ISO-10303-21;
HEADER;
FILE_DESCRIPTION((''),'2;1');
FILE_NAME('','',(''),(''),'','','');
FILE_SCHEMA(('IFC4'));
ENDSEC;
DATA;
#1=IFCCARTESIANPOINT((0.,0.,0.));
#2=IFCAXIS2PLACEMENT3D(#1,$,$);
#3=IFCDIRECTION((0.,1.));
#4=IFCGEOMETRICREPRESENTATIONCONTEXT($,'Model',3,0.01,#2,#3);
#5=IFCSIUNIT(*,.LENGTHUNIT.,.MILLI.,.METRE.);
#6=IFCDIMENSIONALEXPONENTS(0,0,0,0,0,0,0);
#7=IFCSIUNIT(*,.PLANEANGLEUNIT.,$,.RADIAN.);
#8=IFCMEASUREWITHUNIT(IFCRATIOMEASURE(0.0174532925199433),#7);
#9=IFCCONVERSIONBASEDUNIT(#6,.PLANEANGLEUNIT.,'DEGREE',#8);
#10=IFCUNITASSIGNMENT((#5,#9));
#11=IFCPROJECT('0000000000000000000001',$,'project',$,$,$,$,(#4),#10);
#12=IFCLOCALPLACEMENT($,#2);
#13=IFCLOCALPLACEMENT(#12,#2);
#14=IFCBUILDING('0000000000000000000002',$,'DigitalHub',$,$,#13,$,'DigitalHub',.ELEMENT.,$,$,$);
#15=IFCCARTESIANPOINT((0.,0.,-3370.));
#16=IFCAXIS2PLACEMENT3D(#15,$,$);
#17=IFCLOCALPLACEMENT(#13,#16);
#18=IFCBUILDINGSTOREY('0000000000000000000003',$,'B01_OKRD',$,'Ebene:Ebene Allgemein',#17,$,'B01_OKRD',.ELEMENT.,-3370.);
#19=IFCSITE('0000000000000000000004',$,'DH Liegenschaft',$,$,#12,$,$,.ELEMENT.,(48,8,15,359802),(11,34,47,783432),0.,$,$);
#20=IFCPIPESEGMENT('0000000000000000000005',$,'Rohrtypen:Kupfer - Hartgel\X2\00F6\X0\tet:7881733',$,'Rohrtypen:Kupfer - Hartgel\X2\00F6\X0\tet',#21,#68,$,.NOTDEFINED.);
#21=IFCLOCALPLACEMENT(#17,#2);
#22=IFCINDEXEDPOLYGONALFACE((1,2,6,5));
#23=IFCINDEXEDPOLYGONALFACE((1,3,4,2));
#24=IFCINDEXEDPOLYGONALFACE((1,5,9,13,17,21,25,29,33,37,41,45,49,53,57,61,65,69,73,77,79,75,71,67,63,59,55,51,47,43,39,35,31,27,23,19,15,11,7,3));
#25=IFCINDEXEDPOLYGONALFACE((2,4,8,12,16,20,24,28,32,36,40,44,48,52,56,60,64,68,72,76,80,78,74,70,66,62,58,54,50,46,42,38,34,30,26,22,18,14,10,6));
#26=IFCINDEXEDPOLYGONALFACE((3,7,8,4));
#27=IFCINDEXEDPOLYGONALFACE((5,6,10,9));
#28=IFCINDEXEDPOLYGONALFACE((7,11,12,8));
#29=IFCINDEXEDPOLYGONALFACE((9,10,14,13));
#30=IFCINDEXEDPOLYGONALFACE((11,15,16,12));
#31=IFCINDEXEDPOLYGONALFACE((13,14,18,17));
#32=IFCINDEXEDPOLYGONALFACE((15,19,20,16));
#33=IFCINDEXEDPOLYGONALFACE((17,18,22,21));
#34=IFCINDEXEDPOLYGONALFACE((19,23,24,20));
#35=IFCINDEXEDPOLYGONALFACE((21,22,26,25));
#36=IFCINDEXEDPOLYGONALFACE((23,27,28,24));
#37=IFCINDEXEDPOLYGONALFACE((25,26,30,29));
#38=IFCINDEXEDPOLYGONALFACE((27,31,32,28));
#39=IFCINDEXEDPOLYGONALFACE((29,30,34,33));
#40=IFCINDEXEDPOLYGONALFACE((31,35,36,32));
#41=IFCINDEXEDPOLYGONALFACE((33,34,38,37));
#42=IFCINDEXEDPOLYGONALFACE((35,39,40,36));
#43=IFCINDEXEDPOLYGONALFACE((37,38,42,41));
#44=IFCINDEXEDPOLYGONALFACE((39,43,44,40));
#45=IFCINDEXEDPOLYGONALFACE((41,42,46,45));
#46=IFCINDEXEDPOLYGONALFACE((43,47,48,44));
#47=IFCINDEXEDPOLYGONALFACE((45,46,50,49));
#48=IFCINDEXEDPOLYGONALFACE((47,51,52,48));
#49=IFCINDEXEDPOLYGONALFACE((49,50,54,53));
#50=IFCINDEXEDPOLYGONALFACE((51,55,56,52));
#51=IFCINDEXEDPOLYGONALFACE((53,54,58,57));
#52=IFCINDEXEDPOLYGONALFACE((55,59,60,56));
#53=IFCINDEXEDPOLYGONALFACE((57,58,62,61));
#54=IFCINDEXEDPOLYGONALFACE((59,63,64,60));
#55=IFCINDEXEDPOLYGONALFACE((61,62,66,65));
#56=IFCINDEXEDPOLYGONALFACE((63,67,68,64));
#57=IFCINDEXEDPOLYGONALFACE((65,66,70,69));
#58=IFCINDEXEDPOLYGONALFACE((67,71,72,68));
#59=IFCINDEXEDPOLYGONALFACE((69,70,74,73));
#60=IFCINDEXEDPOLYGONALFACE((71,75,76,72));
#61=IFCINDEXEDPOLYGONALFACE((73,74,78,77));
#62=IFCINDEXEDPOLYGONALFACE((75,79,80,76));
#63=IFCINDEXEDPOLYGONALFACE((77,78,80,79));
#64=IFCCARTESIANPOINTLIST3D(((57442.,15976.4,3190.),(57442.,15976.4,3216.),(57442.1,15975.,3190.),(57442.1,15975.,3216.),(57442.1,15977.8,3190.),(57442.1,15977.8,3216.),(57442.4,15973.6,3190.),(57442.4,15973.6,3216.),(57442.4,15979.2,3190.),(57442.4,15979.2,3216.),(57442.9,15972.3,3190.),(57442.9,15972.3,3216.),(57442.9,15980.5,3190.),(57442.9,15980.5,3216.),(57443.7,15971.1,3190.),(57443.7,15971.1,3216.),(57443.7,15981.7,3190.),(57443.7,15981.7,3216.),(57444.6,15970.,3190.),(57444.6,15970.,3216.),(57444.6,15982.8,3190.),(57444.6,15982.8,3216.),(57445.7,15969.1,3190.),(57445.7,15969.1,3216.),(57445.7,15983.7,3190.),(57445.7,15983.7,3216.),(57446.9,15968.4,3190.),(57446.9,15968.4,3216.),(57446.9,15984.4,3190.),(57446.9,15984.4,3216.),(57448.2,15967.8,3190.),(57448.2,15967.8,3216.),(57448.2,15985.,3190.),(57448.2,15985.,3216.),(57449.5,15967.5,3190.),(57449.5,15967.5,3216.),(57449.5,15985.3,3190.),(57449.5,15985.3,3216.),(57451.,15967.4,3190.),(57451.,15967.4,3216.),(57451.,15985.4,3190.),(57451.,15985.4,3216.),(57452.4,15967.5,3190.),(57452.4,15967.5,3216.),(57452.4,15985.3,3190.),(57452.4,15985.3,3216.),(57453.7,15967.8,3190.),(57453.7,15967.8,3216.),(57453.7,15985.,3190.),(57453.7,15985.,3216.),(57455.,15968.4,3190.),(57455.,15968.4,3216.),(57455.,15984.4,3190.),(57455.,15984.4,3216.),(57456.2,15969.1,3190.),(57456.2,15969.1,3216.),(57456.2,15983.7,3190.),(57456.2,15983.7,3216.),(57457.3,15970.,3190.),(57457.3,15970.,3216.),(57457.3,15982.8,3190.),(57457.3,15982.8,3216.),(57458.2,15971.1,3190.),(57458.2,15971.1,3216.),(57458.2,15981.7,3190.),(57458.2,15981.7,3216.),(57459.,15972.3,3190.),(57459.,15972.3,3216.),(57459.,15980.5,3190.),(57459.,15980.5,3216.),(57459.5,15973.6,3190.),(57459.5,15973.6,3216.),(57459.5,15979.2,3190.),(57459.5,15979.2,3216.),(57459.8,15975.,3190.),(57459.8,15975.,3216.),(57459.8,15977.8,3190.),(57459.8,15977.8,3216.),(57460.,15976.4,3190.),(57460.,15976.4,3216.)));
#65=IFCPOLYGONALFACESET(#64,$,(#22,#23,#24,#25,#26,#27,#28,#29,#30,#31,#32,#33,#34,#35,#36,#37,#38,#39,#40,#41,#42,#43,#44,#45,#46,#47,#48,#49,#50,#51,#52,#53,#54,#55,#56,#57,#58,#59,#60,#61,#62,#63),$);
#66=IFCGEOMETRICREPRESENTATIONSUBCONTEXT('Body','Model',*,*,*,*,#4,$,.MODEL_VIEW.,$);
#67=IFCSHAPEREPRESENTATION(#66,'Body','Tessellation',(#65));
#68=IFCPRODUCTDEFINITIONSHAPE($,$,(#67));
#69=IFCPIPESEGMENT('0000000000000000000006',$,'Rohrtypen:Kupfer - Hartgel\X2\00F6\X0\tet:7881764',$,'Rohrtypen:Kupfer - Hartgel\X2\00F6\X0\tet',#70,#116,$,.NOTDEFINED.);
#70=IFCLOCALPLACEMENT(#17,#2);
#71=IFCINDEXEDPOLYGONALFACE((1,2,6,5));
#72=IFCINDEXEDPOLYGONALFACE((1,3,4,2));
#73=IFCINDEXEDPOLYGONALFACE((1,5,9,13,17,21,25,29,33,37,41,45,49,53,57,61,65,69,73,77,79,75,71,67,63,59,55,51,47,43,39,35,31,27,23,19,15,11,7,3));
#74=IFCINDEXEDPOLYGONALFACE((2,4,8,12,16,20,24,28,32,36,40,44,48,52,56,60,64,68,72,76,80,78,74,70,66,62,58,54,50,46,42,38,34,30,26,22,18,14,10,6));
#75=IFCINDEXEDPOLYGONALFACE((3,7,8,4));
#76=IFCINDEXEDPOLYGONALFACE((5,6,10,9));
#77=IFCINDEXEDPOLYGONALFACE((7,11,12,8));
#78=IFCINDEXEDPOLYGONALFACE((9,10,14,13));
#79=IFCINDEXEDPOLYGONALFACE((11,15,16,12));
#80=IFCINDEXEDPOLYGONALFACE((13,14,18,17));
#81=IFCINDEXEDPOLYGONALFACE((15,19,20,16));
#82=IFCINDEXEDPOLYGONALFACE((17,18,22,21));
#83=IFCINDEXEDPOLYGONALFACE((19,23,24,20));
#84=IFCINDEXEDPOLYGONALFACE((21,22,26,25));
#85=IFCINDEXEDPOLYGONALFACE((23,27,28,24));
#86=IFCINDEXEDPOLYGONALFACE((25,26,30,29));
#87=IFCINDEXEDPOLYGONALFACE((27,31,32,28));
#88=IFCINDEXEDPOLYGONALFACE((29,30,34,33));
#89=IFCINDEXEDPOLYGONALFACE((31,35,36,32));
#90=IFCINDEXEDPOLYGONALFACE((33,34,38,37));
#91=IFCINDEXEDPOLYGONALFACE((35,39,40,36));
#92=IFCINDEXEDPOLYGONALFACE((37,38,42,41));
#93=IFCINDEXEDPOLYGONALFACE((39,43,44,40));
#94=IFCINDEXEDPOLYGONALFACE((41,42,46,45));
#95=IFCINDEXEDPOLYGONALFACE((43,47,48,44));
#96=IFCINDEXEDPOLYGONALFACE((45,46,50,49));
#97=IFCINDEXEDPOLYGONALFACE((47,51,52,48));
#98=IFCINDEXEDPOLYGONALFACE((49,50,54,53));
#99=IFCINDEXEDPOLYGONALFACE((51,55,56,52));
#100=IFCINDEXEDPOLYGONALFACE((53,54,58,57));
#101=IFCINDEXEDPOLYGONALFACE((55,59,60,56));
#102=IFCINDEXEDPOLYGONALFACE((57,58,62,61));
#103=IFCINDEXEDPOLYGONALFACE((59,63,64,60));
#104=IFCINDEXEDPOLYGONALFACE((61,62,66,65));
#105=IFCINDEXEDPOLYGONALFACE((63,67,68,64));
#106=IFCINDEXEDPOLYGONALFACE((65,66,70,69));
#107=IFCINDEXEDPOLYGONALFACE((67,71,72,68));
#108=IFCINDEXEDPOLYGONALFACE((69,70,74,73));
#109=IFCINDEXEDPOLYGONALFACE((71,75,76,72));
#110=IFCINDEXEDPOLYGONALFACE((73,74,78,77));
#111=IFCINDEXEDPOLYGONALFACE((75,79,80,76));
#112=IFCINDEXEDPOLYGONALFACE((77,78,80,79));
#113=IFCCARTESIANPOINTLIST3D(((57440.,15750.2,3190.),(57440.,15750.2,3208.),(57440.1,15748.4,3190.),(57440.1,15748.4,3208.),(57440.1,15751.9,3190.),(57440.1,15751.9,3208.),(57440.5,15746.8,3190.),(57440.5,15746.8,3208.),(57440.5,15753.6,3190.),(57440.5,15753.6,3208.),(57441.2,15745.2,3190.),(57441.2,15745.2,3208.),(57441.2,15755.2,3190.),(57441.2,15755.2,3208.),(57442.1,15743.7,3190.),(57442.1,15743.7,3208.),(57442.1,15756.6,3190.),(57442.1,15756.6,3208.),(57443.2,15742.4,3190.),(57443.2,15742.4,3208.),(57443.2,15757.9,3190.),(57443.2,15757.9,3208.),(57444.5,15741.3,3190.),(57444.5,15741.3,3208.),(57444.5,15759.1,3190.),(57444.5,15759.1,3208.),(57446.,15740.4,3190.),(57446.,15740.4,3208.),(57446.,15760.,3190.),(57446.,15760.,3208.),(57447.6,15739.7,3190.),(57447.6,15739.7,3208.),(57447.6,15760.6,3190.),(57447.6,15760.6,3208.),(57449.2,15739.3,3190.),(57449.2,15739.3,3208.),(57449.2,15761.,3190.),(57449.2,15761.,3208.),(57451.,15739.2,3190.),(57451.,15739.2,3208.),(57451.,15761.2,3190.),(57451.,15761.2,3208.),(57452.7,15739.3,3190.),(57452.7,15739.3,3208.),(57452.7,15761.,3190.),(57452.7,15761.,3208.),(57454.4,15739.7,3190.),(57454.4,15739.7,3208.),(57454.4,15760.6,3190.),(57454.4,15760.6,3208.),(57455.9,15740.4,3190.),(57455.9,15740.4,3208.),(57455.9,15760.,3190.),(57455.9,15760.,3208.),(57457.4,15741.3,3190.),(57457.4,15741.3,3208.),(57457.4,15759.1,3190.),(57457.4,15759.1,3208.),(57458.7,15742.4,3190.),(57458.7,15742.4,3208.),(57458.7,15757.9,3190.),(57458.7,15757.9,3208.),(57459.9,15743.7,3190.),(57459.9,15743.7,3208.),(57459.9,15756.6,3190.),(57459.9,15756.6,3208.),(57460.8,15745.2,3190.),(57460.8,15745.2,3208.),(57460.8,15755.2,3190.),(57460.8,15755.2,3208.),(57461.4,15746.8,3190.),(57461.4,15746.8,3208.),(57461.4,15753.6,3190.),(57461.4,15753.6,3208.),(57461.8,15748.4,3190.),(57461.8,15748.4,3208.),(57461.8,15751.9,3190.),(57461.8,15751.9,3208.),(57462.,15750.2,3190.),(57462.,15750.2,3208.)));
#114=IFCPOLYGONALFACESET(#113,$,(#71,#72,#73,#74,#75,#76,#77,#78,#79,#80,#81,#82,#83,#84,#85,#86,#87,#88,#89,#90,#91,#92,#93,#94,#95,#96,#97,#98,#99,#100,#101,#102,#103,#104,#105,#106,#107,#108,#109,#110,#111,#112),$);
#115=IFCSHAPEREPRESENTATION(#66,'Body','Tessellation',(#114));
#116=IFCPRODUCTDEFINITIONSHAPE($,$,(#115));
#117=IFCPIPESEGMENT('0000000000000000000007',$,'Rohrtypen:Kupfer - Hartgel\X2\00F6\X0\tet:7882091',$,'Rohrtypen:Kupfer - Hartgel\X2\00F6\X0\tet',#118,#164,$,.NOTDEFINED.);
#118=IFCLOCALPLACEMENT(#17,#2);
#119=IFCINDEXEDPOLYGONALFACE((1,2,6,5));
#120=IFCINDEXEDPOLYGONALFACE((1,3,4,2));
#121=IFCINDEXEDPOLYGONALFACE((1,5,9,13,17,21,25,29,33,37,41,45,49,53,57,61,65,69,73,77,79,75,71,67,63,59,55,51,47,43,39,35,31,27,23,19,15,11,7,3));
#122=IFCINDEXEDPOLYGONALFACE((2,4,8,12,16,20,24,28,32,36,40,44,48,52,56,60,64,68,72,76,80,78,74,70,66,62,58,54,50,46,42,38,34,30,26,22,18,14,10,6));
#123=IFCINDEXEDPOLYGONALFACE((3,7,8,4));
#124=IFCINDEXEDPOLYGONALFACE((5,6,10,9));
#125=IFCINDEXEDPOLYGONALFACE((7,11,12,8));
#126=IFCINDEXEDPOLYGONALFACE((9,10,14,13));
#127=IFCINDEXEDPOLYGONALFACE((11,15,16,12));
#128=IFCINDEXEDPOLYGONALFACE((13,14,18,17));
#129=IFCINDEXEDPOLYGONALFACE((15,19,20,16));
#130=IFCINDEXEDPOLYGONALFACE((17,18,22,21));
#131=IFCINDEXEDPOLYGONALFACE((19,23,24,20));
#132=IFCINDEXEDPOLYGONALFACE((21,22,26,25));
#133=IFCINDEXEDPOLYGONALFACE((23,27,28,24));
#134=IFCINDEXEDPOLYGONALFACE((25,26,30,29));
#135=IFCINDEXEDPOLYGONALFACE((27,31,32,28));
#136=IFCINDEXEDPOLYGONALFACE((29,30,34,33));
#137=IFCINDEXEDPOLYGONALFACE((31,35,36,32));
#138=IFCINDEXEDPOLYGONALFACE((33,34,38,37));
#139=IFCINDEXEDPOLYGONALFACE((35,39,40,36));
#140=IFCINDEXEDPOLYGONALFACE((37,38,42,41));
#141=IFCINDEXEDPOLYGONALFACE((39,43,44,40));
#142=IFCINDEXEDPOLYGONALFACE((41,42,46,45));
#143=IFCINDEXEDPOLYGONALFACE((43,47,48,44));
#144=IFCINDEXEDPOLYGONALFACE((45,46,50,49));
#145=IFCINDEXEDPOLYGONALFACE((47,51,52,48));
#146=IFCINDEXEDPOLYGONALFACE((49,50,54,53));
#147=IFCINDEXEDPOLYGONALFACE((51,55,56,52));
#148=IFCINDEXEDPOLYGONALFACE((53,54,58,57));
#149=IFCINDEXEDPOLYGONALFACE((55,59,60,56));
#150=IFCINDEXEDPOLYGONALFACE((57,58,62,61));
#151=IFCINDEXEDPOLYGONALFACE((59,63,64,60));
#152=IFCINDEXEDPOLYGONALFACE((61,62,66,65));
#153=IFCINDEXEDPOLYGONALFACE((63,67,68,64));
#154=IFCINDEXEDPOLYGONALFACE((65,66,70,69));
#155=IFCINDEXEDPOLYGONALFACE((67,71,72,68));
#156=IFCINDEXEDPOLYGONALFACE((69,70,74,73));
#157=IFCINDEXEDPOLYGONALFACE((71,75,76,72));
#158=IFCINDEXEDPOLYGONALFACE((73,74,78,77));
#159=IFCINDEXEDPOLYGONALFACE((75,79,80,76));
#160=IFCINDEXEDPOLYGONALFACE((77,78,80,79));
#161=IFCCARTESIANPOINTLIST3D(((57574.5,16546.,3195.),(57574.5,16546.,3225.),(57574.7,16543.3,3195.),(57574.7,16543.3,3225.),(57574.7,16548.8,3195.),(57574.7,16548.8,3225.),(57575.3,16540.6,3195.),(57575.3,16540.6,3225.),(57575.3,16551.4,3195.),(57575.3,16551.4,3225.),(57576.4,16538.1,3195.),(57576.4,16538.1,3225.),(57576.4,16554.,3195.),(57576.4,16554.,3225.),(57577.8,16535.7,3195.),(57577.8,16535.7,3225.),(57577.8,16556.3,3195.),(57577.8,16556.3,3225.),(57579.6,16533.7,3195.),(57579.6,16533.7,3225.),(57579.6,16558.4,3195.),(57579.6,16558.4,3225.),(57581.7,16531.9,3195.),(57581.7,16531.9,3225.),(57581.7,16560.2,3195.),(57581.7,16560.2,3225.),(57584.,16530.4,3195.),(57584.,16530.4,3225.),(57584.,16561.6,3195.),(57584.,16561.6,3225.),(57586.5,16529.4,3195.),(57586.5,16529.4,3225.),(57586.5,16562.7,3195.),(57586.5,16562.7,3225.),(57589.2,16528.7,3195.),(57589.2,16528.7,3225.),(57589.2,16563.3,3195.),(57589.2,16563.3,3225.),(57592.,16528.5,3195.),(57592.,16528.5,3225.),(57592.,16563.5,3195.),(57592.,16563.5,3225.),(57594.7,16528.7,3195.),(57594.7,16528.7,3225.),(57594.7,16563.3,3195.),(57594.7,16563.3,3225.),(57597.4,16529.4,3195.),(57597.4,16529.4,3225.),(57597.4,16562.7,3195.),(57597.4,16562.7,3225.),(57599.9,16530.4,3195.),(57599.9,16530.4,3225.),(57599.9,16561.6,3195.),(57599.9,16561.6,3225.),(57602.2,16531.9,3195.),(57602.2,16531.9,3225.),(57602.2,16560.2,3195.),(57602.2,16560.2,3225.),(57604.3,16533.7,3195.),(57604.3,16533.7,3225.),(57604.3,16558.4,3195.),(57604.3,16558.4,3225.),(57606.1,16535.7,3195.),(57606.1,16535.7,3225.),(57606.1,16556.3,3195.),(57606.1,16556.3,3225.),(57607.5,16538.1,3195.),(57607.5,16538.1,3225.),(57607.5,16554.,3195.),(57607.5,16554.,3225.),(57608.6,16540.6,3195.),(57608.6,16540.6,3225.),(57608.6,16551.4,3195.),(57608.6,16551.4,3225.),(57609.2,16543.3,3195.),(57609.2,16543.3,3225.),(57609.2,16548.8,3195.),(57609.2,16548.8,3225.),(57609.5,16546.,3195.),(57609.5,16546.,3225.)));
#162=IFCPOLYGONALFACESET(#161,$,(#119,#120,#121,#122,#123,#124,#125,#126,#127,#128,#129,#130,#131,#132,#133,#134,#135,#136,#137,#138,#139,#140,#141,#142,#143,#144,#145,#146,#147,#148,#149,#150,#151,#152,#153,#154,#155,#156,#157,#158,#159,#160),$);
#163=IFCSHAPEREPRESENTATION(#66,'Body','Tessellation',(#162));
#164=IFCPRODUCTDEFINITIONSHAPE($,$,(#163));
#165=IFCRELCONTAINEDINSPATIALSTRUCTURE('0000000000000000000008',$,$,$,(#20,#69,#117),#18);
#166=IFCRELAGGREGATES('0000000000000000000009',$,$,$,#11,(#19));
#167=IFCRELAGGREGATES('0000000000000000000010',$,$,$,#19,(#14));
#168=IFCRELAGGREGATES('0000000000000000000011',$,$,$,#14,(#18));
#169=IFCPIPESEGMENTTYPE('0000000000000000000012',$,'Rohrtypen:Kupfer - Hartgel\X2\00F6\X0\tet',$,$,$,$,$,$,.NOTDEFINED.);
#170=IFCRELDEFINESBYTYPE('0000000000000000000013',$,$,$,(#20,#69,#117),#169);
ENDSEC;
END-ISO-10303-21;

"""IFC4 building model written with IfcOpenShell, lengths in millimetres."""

from ifc_helpers import new_model, entity, si_unit, converted_unit, direction, frame, origin, place, context, subcontext, project, spatial, indexed_curve, outline, extrude, type_object, element, save


model = new_model("IFC4")

# Units and contexts
model_context = context("Model", 3, precision=0.01, world=origin(), true_north=direction((0.0, 1.0)))
body_context = subcontext(model_context, "Body", "Model", "MODEL_VIEW")
ifc_project = project(units=[si_unit("LENGTHUNIT", "METRE", prefix="MILLI"), converted_unit("PLANEANGLEUNIT", "DEGREE", entity("IfcRatioMeasure", 0.0174532925199433), si_unit("PLANEANGLEUNIT", "RADIAN"), dimensions=[0, 0, 0, 0, 0, 0, 0])], contexts=[model_context])

# Site, building, storey
site_placement = place(None, origin())
site = spatial("IfcSite", under=ifc_project, at=site_placement, Name="DH Liegenschaft", CompositionType="ELEMENT", RefLatitude=(48, 8, 15, 359802), RefLongitude=(11, 34, 47, 783432), RefElevation=0.0)
building_placement = place(site_placement, origin())
building = spatial("IfcBuilding", under=site, at=building_placement, Name="DigitalHub", LongName="DigitalHub", CompositionType="ELEMENT")
storey_placement = place(building_placement, frame((0.0, 0.0, -3370.0)))
storey = spatial("IfcBuildingStorey", under=building, at=storey_placement, Name="B01_OKRD", ObjectType="Ebene:Ebene Allgemein", LongName="B01_OKRD", CompositionType="ELEMENT", Elevation=-3370.0)

# Pipe segments
pipe_segment_type = type_object("IfcPipeSegmentType", Name="Rohrtypen:Kupfer - Hartgelötet", PredefinedType="NOTDEFINED")
pipe_segment_1_placement = place(storey_placement, frame((57440.4, 15965.8, 3190.0)))
element("IfcPipeSegment", 1, at=pipe_segment_1_placement, inside=storey, type_object=pipe_segment_type, Name="Rohrtypen:Kupfer - Hartgelötet:7881733", ObjectType="Rohrtypen:Kupfer - Hartgelötet", PredefinedType="NOTDEFINED", context=body_context, shape_type="SweptSolid", body=[
    extrude(outline(indexed_curve([(9.0, 0.0), (8.9, 1.4), (8.6, 2.8), (8.0, 4.1), (7.3, 5.3), (6.4, 6.4), (5.3, 7.3), (4.1, 8.0), (2.8, 8.6), (1.4, 8.9), (0.0, 9.0), (-1.4, 8.9), (-2.8, 8.6), (-4.1, 8.0), (-5.3, 7.3), (-6.4, 6.4), (-7.3, 5.3), (-8.0, 4.1), (-8.6, 2.8), (-8.9, 1.4), (-9.0, 0.0), (-8.9, -1.4), (-8.6, -2.8), (-8.0, -4.1), (-7.3, -5.3), (-6.4, -6.4), (-5.3, -7.3), (-4.1, -8.0), (-2.8, -8.6), (-1.4, -8.9), (0.0, -9.0), (1.4, -8.9), (2.8, -8.6), (4.1, -8.0), (5.3, -7.3), (6.4, -6.4), (7.3, -5.3), (8.0, -4.1), (8.6, -2.8), (8.9, -1.4), (9.0, 0.0)], self_intersect=False)), frame((10.6, 10.6, 0.0)), (0.0, 0.0, 1.0), 26.0),
])
pipe_segment_2_placement = place(storey_placement, frame((57438.4, 15737.6, 3190.0)))
element("IfcPipeSegment", 2, at=pipe_segment_2_placement, inside=storey, type_object=pipe_segment_type, Name="Rohrtypen:Kupfer - Hartgelötet:7881764", ObjectType="Rohrtypen:Kupfer - Hartgelötet", PredefinedType="NOTDEFINED", context=body_context, shape_type="SweptSolid", body=[
    extrude(outline(indexed_curve([(11.0, 0.0), (10.9, 1.7), (10.5, 3.4), (9.8, 5.0), (8.9, 6.5), (7.8, 7.8), (6.5, 8.9), (5.0, 9.8), (3.4, 10.5), (1.7, 10.9), (0.0, 11.0), (-1.7, 10.9), (-3.4, 10.5), (-5.0, 9.8), (-6.5, 8.9), (-7.8, 7.8), (-8.9, 6.5), (-9.8, 5.0), (-10.5, 3.4), (-10.9, 1.7), (-11.0, 0.0), (-10.9, -1.7), (-10.5, -3.4), (-9.8, -5.0), (-8.9, -6.5), (-7.8, -7.8), (-6.5, -8.9), (-5.0, -9.8), (-3.4, -10.5), (-1.7, -10.9), (0.0, -11.0), (1.7, -10.9), (3.4, -10.5), (5.0, -9.8), (6.5, -8.9), (7.8, -7.8), (8.9, -6.5), (9.8, -5.0), (10.5, -3.4), (10.9, -1.7), (11.0, 0.0)], self_intersect=False)), frame((12.6, 12.6, 0.0)), (0.0, 0.0, 1.0), 18.0),
])
pipe_segment_3_placement = place(storey_placement, frame((57572.9, 16526.9, 3195.0)))
element("IfcPipeSegment", 3, at=pipe_segment_3_placement, inside=storey, type_object=pipe_segment_type, Name="Rohrtypen:Kupfer - Hartgelötet:7882091", ObjectType="Rohrtypen:Kupfer - Hartgelötet", PredefinedType="NOTDEFINED", context=body_context, shape_type="SweptSolid", body=[
    extrude(outline(indexed_curve([(17.5, 0.0), (17.3, 2.7), (16.6, 5.4), (15.6, 7.9), (14.2, 10.3), (12.4, 12.4), (10.3, 14.2), (7.9, 15.6), (5.4, 16.6), (2.7, 17.3), (0.0, 17.5), (-2.7, 17.3), (-5.4, 16.6), (-7.9, 15.6), (-10.3, 14.2), (-12.4, 12.4), (-14.2, 10.3), (-15.6, 7.9), (-16.6, 5.4), (-17.3, 2.7), (-17.5, 0.0), (-17.3, -2.7), (-16.6, -5.4), (-15.6, -7.9), (-14.2, -10.3), (-12.4, -12.4), (-10.3, -14.2), (-7.9, -15.6), (-5.4, -16.6), (-2.7, -17.3), (0.0, -17.5), (2.7, -17.3), (5.4, -16.6), (7.9, -15.6), (10.3, -14.2), (12.4, -12.4), (14.2, -10.3), (15.6, -7.9), (16.6, -5.4), (17.3, -2.7), (17.5, 0.0)], self_intersect=False)), frame((19.1, 19.1, 0.0), z_axis=(0.0, 0.0, 1.0), x_axis=(-1.0, 0.0, 0.0)), (0.0, 0.0, 1.0), 30.0),
])

save(model, "model.ifc")
